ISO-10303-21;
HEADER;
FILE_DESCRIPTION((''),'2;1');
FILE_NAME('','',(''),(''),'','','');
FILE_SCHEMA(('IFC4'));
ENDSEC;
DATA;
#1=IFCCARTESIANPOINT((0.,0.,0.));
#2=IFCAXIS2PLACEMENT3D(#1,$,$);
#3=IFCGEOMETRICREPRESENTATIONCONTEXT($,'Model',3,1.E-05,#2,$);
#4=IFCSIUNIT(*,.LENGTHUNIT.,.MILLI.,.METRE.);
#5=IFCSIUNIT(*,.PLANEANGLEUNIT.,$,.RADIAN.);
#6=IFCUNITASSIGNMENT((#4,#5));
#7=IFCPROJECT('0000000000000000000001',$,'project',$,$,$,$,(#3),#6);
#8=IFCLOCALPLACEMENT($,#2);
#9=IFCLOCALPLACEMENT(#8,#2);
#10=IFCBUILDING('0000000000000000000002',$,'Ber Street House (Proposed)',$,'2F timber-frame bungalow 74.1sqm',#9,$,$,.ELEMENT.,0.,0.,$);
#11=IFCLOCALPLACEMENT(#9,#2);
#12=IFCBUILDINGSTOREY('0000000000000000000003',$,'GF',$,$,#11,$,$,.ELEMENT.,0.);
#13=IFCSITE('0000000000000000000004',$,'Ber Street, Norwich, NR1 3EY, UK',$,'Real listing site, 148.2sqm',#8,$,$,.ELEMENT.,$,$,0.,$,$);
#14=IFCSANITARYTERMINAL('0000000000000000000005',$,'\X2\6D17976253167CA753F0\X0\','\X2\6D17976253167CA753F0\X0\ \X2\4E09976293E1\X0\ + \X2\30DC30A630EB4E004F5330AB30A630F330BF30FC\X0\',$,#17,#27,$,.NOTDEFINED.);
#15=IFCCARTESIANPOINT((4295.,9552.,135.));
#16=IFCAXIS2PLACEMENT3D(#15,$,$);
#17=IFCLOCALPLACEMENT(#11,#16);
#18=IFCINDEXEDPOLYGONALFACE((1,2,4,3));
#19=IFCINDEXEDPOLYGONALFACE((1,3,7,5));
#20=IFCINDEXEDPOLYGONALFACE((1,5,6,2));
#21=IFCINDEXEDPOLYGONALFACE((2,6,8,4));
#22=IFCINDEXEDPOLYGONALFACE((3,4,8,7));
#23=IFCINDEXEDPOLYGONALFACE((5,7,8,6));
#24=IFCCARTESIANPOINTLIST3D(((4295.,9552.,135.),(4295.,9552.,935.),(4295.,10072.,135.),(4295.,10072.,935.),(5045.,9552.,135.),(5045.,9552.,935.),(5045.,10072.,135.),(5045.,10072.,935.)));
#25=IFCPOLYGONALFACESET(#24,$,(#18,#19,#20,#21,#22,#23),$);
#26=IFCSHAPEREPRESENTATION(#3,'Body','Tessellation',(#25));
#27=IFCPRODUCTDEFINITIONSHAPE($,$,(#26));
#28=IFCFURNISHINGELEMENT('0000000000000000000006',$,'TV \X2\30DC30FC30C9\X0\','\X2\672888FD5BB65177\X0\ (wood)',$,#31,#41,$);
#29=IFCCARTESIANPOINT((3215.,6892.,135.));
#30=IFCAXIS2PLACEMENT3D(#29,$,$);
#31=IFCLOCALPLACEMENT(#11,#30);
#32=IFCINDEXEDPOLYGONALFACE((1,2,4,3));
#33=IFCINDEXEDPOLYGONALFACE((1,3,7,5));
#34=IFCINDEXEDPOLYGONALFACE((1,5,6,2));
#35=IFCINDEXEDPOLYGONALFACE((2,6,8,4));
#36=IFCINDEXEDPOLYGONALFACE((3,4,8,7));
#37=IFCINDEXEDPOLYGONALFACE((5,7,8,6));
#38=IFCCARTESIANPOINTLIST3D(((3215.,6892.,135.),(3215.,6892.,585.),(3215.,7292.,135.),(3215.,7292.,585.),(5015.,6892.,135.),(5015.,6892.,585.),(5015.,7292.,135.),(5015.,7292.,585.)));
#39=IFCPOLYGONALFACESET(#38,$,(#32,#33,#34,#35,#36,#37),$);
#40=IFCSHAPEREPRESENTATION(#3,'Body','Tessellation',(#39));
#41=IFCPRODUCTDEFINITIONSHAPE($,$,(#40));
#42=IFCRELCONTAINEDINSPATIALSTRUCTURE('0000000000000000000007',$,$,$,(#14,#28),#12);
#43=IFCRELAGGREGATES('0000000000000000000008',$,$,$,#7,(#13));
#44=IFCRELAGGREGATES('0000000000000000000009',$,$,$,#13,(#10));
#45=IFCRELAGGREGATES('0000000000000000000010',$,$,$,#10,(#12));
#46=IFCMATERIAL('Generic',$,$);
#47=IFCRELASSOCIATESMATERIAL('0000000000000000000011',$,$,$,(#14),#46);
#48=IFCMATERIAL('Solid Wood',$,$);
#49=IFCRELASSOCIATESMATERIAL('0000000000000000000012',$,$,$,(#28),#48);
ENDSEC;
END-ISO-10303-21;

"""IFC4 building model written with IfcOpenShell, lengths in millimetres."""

from ifc_helpers import new_model, si_unit, frame, frame_2d, origin, place, context, project, spatial, rectangle, extrude, material, element, save


model = new_model("IFC4")

# Units and contexts
model_context = context("Model", 3, precision=1e-05, world=origin())
ifc_project = project(units=[si_unit("LENGTHUNIT", "METRE", prefix="MILLI"), si_unit("PLANEANGLEUNIT", "RADIAN")], contexts=[model_context])

# Site, building, storey
site_placement = place(None, origin())
site = spatial("IfcSite", under=ifc_project, at=site_placement, Name="Ber Street, Norwich, NR1 3EY, UK", ObjectType="Real listing site, 148.2sqm", CompositionType="ELEMENT", RefElevation=0.0)
building_placement = place(site_placement, origin())
building = spatial("IfcBuilding", under=site, at=building_placement, Name="Ber Street House (Proposed)", ObjectType="2F timber-frame bungalow 74.1sqm", CompositionType="ELEMENT", ElevationOfRefHeight=0.0, ElevationOfTerrain=0.0)
storey_placement = place(building_placement, origin())
storey = spatial("IfcBuildingStorey", under=building, at=storey_placement, Name="GF", CompositionType="ELEMENT", Elevation=0.0)

# Shared definitions
ifc_material_1 = material(Name="Solid Wood")

# Shared definitions
ifc_material_2 = material(Name="Generic")

# Sanitary terminal
sanitary_terminal_1_placement = place(storey_placement, frame((4295.0, 9552.0, 135.0)))
element("IfcSanitaryTerminal", 1, at=sanitary_terminal_1_placement, inside=storey, material=ifc_material_2, Name="洗面化粧台", Description="洗面化粧台 三面鏡 + ボウル一体カウンター", PredefinedType="NOTDEFINED", context=model_context, shape_type="SweptSolid", body=[
    extrude(rectangle(XDim=750.0, YDim=520.0, at=frame_2d((375.0, 260.0))), frame((4295.0, 9552.0, 135.0)), (0.0, 0.0, 1.0), 800.0),
])

# Furnishing element
furnishing_placement = place(storey_placement, frame((3215.0, 6892.0, 135.0)))
element("IfcFurnishingElement", 2, at=furnishing_placement, inside=storey, material=ifc_material_1, Name="TV ボード", Description="木製家具 (wood)", context=model_context, shape_type="SweptSolid", body=[
    extrude(rectangle(XDim=1800.0, YDim=400.0, at=frame_2d((900.0, 200.0))), frame((3215.0, 6892.0, 135.0)), (0.0, 0.0, 1.0), 450.0),
])

save(model, "model.ifc")
